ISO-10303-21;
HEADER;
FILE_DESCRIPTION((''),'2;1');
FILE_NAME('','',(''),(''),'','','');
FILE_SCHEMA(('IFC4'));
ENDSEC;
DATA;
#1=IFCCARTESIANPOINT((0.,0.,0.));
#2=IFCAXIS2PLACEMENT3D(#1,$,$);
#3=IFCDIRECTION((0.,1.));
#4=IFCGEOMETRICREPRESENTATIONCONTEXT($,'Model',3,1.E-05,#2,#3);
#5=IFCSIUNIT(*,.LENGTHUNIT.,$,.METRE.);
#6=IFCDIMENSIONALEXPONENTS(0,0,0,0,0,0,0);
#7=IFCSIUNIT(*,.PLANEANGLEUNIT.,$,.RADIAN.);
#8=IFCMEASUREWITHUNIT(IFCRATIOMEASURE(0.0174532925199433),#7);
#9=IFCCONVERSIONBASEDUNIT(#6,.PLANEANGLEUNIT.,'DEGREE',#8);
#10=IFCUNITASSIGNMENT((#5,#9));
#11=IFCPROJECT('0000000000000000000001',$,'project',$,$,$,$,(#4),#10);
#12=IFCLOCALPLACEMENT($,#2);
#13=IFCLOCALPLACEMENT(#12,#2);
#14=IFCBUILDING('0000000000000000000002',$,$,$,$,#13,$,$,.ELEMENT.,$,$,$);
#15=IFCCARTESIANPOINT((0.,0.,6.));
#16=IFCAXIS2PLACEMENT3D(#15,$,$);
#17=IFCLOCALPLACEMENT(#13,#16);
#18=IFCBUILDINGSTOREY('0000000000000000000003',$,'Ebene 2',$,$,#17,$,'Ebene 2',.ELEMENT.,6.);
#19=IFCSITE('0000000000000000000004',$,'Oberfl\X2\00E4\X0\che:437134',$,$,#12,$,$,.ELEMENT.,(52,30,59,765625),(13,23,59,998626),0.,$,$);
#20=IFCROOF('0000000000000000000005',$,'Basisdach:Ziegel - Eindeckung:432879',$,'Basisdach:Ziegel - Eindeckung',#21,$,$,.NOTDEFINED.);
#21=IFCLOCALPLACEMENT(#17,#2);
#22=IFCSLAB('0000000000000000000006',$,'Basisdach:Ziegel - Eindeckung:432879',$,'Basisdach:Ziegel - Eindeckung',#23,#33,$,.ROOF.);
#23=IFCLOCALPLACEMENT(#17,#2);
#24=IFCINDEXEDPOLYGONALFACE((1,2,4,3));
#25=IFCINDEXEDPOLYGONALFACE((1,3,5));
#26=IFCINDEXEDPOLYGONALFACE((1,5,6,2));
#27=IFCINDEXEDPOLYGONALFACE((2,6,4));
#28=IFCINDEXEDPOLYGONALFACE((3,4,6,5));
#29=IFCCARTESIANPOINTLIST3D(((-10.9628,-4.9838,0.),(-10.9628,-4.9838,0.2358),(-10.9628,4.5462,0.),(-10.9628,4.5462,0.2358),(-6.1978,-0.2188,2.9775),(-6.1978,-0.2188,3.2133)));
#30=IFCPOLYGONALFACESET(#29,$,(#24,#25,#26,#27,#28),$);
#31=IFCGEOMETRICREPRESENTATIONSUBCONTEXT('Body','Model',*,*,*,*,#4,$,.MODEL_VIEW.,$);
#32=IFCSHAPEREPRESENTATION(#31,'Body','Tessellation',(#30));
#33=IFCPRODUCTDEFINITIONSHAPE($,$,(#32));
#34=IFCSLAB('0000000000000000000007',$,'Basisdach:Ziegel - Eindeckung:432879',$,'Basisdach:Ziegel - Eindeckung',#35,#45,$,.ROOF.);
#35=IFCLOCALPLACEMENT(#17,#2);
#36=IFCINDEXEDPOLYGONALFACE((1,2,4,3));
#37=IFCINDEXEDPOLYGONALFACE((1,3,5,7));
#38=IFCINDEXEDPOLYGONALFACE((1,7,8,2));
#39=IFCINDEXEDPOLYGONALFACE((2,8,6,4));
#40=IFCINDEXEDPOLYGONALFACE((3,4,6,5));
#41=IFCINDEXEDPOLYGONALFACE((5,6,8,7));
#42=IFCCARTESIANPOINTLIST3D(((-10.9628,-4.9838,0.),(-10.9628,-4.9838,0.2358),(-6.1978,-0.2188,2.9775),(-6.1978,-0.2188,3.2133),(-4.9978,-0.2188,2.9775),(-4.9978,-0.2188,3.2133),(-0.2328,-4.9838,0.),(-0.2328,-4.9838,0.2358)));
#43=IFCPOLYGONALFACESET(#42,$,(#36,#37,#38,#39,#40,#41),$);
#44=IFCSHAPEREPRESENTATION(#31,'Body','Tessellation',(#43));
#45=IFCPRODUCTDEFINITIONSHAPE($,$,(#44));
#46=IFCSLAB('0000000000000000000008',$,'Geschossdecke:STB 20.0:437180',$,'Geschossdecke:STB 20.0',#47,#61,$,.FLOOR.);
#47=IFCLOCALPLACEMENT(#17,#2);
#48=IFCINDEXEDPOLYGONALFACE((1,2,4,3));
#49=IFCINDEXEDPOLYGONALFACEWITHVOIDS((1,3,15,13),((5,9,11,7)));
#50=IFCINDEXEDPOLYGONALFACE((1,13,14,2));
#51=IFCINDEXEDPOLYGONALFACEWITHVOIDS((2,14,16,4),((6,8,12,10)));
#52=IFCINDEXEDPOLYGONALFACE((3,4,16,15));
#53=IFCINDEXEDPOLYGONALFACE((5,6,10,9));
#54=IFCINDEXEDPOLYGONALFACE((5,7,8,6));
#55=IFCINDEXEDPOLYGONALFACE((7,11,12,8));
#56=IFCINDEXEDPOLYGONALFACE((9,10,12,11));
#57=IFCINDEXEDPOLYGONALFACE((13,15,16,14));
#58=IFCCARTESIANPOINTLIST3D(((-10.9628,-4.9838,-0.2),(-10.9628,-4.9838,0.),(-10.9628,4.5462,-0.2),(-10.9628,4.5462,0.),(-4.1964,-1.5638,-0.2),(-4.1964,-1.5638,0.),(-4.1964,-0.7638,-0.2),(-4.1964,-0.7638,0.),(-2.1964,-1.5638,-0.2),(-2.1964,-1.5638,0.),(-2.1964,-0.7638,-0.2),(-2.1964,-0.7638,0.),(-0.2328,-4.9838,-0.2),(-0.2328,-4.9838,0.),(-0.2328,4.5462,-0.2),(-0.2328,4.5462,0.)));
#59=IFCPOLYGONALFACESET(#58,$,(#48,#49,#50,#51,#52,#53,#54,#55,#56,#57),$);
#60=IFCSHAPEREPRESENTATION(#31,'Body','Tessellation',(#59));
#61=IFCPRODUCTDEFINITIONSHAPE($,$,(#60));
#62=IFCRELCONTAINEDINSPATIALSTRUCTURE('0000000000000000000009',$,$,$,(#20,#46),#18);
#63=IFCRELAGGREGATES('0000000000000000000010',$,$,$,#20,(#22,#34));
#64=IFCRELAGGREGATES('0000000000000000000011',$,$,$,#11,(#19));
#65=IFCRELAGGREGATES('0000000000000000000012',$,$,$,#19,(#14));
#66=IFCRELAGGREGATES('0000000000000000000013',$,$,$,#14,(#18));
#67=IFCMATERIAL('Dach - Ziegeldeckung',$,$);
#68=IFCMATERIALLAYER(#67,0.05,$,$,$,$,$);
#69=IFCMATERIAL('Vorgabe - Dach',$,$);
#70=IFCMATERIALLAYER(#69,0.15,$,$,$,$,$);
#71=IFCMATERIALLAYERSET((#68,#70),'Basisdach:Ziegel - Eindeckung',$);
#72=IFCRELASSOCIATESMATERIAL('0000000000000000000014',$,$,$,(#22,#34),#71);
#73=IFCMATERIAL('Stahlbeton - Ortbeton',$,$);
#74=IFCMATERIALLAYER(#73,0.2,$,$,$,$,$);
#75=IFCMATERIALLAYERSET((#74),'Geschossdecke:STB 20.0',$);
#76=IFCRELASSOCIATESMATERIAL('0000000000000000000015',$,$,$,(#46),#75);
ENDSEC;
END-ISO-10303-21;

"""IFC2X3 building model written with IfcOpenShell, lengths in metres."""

from ifc_helpers import new_model, entity, si_unit, converted_unit, direction, frame, frame_2d, origin, origin_2d_with_axis, place, context, subcontext, project, spatial, polyline, rectangle, outline, extrude, material, layer, layer_set, layer_usage, element, aggregate, save


model = new_model("IFC2X3")

# Units and contexts
model_context = context("Model", 3, precision=1e-05, world=origin(), true_north=direction((0.0, 1.0)))
body_context = subcontext(model_context, "Body", "Model", "MODEL_VIEW")
ifc_project = project(units=[si_unit("LENGTHUNIT", "METRE"), converted_unit("PLANEANGLEUNIT", "DEGREE", entity("IfcRatioMeasure", 0.0174532925199433), si_unit("PLANEANGLEUNIT", "RADIAN"), dimensions=[0, 0, 0, 0, 0, 0, 0])], contexts=[model_context])

# Site, building, storey
site_placement = place(None, origin())
site = spatial("IfcSite", under=ifc_project, at=site_placement, Name="Oberfläche:437134", CompositionType="ELEMENT", RefLatitude=(52, 30, 59, 765625), RefLongitude=(13, 23, 59, 998626), RefElevation=0.0)
building_placement = place(site_placement, origin())
building = spatial("IfcBuilding", under=site, at=building_placement, CompositionType="ELEMENT")
storey_placement = place(building_placement, frame((0.0, 0.0, 6.0)))
storey = spatial("IfcBuildingStorey", under=building, at=storey_placement, Name="Ebene 2", LongName="Ebene 2", CompositionType="ELEMENT", Elevation=6.0)

# Roof, slabs
roof_placement = place(storey_placement, frame((-10.9628, -4.9838, 0.0)))
roof = element("IfcRoof", 1, at=roof_placement, inside=storey, Name="Basisdach:Ziegel - Eindeckung:432879", ObjectType="Basisdach:Ziegel - Eindeckung", ShapeType="NOTDEFINED")
ifc_material_1 = material(Name="Dach - Ziegeldeckung")
ifc_layer_1 = layer(ifc_material_1, 0.05)
ifc_material_2 = material(Name="Vorgabe - Dach")
ifc_layer_2 = layer(ifc_material_2, 0.15)
ifc_layer_set_1 = layer_set([ifc_layer_1, ifc_layer_2], Name="Basisdach:Ziegel - Eindeckung")
slab_1_placement = place(roof_placement, origin())
slab_1 = element("IfcSlab", 2, at=slab_1_placement, material=ifc_layer_set_1, Name="Basisdach:Ziegel - Eindeckung:432879", ObjectType="Basisdach:Ziegel - Eindeckung", PredefinedType="ROOF", context=body_context, shape_type="SweptSolid", body=[
    extrude(outline(polyline([(-2.8094, 4.765), (-2.8094, -4.765), (2.8094, 0.0), (-2.8094, 4.765)])), frame((2.3825, 4.765, 1.4888), z_axis=(-0.529919, 0.0, 0.848048), x_axis=(0.848048, 0.0, 0.529919)), (0.529919, 0.0, 0.848048), 0.2358),
])
slab_2_placement = place(roof_placement, origin())
slab_2 = element("IfcSlab", 3, at=slab_2_placement, material=ifc_layer_set_1, Name="Basisdach:Ziegel - Eindeckung:432879", ObjectType="Basisdach:Ziegel - Eindeckung", PredefinedType="ROOF", context=body_context, shape_type="SweptSolid", body=[
    extrude(outline(polyline([(-5.365, -2.8094), (5.365, -2.8094), (0.6, 2.8094), (-0.6, 2.8094), (-5.365, -2.8094)])), frame((5.365, 2.3825, 1.4888), z_axis=(0.0, -0.529919, 0.848048), x_axis=(1.0, 0.0, 0.0)), (0.0, 0.529919, 0.848048), 0.2358),
])
aggregate(roof, [slab_1, slab_2])

# Slab, opening
ifc_material_3 = material(Name="Stahlbeton - Ortbeton")
ifc_layer_3 = layer(ifc_material_3, 0.2)
ifc_layer_set_2 = layer_set([ifc_layer_3], Name="Geschossdecke:STB 20.0")
ifc_layer_usage = layer_usage(ifc_layer_set_2, "AXIS3", "POSITIVE", 0.0)
slab_3_placement = place(storey_placement, frame((-10.9628, -4.9838, -0.2)))
slab_3 = element("IfcSlab", 4, at=slab_3_placement, inside=storey, material=ifc_layer_usage, Name="Geschossdecke:STB 20.0:437180", ObjectType="Geschossdecke:STB 20.0", PredefinedType="FLOOR", context=body_context, shape_type="SweptSolid", body=[
    extrude(rectangle(XDim=9.53, YDim=10.73, at=frame_2d((0.0, 0.0), x_axis=(0.0, -1.0))), frame((5.365, 4.765, 0.2), z_axis=(0.0, 0.0, -1.0), x_axis=(-1.0, 0.0, 0.0)), (0.0, 0.0, 1.0), 0.2),
])
opening_placement = place(slab_3_placement, frame((7.7664, 3.82, 0.2)))
element("IfcOpeningElement", 5, at=opening_placement, cuts=slab_3, ObjectType="Opening", context=body_context, shape_type="SweptSolid", body=[
    extrude(rectangle(XDim=0.8, YDim=2.0, at=origin_2d_with_axis()), frame((0.0, 0.0, 0.0), z_axis=(0.0, 0.0, -1.0), x_axis=(0.0, -1.0, 0.0)), (0.0, 0.0, 1.0), 0.2),
])

save(model, "model.ifc")
